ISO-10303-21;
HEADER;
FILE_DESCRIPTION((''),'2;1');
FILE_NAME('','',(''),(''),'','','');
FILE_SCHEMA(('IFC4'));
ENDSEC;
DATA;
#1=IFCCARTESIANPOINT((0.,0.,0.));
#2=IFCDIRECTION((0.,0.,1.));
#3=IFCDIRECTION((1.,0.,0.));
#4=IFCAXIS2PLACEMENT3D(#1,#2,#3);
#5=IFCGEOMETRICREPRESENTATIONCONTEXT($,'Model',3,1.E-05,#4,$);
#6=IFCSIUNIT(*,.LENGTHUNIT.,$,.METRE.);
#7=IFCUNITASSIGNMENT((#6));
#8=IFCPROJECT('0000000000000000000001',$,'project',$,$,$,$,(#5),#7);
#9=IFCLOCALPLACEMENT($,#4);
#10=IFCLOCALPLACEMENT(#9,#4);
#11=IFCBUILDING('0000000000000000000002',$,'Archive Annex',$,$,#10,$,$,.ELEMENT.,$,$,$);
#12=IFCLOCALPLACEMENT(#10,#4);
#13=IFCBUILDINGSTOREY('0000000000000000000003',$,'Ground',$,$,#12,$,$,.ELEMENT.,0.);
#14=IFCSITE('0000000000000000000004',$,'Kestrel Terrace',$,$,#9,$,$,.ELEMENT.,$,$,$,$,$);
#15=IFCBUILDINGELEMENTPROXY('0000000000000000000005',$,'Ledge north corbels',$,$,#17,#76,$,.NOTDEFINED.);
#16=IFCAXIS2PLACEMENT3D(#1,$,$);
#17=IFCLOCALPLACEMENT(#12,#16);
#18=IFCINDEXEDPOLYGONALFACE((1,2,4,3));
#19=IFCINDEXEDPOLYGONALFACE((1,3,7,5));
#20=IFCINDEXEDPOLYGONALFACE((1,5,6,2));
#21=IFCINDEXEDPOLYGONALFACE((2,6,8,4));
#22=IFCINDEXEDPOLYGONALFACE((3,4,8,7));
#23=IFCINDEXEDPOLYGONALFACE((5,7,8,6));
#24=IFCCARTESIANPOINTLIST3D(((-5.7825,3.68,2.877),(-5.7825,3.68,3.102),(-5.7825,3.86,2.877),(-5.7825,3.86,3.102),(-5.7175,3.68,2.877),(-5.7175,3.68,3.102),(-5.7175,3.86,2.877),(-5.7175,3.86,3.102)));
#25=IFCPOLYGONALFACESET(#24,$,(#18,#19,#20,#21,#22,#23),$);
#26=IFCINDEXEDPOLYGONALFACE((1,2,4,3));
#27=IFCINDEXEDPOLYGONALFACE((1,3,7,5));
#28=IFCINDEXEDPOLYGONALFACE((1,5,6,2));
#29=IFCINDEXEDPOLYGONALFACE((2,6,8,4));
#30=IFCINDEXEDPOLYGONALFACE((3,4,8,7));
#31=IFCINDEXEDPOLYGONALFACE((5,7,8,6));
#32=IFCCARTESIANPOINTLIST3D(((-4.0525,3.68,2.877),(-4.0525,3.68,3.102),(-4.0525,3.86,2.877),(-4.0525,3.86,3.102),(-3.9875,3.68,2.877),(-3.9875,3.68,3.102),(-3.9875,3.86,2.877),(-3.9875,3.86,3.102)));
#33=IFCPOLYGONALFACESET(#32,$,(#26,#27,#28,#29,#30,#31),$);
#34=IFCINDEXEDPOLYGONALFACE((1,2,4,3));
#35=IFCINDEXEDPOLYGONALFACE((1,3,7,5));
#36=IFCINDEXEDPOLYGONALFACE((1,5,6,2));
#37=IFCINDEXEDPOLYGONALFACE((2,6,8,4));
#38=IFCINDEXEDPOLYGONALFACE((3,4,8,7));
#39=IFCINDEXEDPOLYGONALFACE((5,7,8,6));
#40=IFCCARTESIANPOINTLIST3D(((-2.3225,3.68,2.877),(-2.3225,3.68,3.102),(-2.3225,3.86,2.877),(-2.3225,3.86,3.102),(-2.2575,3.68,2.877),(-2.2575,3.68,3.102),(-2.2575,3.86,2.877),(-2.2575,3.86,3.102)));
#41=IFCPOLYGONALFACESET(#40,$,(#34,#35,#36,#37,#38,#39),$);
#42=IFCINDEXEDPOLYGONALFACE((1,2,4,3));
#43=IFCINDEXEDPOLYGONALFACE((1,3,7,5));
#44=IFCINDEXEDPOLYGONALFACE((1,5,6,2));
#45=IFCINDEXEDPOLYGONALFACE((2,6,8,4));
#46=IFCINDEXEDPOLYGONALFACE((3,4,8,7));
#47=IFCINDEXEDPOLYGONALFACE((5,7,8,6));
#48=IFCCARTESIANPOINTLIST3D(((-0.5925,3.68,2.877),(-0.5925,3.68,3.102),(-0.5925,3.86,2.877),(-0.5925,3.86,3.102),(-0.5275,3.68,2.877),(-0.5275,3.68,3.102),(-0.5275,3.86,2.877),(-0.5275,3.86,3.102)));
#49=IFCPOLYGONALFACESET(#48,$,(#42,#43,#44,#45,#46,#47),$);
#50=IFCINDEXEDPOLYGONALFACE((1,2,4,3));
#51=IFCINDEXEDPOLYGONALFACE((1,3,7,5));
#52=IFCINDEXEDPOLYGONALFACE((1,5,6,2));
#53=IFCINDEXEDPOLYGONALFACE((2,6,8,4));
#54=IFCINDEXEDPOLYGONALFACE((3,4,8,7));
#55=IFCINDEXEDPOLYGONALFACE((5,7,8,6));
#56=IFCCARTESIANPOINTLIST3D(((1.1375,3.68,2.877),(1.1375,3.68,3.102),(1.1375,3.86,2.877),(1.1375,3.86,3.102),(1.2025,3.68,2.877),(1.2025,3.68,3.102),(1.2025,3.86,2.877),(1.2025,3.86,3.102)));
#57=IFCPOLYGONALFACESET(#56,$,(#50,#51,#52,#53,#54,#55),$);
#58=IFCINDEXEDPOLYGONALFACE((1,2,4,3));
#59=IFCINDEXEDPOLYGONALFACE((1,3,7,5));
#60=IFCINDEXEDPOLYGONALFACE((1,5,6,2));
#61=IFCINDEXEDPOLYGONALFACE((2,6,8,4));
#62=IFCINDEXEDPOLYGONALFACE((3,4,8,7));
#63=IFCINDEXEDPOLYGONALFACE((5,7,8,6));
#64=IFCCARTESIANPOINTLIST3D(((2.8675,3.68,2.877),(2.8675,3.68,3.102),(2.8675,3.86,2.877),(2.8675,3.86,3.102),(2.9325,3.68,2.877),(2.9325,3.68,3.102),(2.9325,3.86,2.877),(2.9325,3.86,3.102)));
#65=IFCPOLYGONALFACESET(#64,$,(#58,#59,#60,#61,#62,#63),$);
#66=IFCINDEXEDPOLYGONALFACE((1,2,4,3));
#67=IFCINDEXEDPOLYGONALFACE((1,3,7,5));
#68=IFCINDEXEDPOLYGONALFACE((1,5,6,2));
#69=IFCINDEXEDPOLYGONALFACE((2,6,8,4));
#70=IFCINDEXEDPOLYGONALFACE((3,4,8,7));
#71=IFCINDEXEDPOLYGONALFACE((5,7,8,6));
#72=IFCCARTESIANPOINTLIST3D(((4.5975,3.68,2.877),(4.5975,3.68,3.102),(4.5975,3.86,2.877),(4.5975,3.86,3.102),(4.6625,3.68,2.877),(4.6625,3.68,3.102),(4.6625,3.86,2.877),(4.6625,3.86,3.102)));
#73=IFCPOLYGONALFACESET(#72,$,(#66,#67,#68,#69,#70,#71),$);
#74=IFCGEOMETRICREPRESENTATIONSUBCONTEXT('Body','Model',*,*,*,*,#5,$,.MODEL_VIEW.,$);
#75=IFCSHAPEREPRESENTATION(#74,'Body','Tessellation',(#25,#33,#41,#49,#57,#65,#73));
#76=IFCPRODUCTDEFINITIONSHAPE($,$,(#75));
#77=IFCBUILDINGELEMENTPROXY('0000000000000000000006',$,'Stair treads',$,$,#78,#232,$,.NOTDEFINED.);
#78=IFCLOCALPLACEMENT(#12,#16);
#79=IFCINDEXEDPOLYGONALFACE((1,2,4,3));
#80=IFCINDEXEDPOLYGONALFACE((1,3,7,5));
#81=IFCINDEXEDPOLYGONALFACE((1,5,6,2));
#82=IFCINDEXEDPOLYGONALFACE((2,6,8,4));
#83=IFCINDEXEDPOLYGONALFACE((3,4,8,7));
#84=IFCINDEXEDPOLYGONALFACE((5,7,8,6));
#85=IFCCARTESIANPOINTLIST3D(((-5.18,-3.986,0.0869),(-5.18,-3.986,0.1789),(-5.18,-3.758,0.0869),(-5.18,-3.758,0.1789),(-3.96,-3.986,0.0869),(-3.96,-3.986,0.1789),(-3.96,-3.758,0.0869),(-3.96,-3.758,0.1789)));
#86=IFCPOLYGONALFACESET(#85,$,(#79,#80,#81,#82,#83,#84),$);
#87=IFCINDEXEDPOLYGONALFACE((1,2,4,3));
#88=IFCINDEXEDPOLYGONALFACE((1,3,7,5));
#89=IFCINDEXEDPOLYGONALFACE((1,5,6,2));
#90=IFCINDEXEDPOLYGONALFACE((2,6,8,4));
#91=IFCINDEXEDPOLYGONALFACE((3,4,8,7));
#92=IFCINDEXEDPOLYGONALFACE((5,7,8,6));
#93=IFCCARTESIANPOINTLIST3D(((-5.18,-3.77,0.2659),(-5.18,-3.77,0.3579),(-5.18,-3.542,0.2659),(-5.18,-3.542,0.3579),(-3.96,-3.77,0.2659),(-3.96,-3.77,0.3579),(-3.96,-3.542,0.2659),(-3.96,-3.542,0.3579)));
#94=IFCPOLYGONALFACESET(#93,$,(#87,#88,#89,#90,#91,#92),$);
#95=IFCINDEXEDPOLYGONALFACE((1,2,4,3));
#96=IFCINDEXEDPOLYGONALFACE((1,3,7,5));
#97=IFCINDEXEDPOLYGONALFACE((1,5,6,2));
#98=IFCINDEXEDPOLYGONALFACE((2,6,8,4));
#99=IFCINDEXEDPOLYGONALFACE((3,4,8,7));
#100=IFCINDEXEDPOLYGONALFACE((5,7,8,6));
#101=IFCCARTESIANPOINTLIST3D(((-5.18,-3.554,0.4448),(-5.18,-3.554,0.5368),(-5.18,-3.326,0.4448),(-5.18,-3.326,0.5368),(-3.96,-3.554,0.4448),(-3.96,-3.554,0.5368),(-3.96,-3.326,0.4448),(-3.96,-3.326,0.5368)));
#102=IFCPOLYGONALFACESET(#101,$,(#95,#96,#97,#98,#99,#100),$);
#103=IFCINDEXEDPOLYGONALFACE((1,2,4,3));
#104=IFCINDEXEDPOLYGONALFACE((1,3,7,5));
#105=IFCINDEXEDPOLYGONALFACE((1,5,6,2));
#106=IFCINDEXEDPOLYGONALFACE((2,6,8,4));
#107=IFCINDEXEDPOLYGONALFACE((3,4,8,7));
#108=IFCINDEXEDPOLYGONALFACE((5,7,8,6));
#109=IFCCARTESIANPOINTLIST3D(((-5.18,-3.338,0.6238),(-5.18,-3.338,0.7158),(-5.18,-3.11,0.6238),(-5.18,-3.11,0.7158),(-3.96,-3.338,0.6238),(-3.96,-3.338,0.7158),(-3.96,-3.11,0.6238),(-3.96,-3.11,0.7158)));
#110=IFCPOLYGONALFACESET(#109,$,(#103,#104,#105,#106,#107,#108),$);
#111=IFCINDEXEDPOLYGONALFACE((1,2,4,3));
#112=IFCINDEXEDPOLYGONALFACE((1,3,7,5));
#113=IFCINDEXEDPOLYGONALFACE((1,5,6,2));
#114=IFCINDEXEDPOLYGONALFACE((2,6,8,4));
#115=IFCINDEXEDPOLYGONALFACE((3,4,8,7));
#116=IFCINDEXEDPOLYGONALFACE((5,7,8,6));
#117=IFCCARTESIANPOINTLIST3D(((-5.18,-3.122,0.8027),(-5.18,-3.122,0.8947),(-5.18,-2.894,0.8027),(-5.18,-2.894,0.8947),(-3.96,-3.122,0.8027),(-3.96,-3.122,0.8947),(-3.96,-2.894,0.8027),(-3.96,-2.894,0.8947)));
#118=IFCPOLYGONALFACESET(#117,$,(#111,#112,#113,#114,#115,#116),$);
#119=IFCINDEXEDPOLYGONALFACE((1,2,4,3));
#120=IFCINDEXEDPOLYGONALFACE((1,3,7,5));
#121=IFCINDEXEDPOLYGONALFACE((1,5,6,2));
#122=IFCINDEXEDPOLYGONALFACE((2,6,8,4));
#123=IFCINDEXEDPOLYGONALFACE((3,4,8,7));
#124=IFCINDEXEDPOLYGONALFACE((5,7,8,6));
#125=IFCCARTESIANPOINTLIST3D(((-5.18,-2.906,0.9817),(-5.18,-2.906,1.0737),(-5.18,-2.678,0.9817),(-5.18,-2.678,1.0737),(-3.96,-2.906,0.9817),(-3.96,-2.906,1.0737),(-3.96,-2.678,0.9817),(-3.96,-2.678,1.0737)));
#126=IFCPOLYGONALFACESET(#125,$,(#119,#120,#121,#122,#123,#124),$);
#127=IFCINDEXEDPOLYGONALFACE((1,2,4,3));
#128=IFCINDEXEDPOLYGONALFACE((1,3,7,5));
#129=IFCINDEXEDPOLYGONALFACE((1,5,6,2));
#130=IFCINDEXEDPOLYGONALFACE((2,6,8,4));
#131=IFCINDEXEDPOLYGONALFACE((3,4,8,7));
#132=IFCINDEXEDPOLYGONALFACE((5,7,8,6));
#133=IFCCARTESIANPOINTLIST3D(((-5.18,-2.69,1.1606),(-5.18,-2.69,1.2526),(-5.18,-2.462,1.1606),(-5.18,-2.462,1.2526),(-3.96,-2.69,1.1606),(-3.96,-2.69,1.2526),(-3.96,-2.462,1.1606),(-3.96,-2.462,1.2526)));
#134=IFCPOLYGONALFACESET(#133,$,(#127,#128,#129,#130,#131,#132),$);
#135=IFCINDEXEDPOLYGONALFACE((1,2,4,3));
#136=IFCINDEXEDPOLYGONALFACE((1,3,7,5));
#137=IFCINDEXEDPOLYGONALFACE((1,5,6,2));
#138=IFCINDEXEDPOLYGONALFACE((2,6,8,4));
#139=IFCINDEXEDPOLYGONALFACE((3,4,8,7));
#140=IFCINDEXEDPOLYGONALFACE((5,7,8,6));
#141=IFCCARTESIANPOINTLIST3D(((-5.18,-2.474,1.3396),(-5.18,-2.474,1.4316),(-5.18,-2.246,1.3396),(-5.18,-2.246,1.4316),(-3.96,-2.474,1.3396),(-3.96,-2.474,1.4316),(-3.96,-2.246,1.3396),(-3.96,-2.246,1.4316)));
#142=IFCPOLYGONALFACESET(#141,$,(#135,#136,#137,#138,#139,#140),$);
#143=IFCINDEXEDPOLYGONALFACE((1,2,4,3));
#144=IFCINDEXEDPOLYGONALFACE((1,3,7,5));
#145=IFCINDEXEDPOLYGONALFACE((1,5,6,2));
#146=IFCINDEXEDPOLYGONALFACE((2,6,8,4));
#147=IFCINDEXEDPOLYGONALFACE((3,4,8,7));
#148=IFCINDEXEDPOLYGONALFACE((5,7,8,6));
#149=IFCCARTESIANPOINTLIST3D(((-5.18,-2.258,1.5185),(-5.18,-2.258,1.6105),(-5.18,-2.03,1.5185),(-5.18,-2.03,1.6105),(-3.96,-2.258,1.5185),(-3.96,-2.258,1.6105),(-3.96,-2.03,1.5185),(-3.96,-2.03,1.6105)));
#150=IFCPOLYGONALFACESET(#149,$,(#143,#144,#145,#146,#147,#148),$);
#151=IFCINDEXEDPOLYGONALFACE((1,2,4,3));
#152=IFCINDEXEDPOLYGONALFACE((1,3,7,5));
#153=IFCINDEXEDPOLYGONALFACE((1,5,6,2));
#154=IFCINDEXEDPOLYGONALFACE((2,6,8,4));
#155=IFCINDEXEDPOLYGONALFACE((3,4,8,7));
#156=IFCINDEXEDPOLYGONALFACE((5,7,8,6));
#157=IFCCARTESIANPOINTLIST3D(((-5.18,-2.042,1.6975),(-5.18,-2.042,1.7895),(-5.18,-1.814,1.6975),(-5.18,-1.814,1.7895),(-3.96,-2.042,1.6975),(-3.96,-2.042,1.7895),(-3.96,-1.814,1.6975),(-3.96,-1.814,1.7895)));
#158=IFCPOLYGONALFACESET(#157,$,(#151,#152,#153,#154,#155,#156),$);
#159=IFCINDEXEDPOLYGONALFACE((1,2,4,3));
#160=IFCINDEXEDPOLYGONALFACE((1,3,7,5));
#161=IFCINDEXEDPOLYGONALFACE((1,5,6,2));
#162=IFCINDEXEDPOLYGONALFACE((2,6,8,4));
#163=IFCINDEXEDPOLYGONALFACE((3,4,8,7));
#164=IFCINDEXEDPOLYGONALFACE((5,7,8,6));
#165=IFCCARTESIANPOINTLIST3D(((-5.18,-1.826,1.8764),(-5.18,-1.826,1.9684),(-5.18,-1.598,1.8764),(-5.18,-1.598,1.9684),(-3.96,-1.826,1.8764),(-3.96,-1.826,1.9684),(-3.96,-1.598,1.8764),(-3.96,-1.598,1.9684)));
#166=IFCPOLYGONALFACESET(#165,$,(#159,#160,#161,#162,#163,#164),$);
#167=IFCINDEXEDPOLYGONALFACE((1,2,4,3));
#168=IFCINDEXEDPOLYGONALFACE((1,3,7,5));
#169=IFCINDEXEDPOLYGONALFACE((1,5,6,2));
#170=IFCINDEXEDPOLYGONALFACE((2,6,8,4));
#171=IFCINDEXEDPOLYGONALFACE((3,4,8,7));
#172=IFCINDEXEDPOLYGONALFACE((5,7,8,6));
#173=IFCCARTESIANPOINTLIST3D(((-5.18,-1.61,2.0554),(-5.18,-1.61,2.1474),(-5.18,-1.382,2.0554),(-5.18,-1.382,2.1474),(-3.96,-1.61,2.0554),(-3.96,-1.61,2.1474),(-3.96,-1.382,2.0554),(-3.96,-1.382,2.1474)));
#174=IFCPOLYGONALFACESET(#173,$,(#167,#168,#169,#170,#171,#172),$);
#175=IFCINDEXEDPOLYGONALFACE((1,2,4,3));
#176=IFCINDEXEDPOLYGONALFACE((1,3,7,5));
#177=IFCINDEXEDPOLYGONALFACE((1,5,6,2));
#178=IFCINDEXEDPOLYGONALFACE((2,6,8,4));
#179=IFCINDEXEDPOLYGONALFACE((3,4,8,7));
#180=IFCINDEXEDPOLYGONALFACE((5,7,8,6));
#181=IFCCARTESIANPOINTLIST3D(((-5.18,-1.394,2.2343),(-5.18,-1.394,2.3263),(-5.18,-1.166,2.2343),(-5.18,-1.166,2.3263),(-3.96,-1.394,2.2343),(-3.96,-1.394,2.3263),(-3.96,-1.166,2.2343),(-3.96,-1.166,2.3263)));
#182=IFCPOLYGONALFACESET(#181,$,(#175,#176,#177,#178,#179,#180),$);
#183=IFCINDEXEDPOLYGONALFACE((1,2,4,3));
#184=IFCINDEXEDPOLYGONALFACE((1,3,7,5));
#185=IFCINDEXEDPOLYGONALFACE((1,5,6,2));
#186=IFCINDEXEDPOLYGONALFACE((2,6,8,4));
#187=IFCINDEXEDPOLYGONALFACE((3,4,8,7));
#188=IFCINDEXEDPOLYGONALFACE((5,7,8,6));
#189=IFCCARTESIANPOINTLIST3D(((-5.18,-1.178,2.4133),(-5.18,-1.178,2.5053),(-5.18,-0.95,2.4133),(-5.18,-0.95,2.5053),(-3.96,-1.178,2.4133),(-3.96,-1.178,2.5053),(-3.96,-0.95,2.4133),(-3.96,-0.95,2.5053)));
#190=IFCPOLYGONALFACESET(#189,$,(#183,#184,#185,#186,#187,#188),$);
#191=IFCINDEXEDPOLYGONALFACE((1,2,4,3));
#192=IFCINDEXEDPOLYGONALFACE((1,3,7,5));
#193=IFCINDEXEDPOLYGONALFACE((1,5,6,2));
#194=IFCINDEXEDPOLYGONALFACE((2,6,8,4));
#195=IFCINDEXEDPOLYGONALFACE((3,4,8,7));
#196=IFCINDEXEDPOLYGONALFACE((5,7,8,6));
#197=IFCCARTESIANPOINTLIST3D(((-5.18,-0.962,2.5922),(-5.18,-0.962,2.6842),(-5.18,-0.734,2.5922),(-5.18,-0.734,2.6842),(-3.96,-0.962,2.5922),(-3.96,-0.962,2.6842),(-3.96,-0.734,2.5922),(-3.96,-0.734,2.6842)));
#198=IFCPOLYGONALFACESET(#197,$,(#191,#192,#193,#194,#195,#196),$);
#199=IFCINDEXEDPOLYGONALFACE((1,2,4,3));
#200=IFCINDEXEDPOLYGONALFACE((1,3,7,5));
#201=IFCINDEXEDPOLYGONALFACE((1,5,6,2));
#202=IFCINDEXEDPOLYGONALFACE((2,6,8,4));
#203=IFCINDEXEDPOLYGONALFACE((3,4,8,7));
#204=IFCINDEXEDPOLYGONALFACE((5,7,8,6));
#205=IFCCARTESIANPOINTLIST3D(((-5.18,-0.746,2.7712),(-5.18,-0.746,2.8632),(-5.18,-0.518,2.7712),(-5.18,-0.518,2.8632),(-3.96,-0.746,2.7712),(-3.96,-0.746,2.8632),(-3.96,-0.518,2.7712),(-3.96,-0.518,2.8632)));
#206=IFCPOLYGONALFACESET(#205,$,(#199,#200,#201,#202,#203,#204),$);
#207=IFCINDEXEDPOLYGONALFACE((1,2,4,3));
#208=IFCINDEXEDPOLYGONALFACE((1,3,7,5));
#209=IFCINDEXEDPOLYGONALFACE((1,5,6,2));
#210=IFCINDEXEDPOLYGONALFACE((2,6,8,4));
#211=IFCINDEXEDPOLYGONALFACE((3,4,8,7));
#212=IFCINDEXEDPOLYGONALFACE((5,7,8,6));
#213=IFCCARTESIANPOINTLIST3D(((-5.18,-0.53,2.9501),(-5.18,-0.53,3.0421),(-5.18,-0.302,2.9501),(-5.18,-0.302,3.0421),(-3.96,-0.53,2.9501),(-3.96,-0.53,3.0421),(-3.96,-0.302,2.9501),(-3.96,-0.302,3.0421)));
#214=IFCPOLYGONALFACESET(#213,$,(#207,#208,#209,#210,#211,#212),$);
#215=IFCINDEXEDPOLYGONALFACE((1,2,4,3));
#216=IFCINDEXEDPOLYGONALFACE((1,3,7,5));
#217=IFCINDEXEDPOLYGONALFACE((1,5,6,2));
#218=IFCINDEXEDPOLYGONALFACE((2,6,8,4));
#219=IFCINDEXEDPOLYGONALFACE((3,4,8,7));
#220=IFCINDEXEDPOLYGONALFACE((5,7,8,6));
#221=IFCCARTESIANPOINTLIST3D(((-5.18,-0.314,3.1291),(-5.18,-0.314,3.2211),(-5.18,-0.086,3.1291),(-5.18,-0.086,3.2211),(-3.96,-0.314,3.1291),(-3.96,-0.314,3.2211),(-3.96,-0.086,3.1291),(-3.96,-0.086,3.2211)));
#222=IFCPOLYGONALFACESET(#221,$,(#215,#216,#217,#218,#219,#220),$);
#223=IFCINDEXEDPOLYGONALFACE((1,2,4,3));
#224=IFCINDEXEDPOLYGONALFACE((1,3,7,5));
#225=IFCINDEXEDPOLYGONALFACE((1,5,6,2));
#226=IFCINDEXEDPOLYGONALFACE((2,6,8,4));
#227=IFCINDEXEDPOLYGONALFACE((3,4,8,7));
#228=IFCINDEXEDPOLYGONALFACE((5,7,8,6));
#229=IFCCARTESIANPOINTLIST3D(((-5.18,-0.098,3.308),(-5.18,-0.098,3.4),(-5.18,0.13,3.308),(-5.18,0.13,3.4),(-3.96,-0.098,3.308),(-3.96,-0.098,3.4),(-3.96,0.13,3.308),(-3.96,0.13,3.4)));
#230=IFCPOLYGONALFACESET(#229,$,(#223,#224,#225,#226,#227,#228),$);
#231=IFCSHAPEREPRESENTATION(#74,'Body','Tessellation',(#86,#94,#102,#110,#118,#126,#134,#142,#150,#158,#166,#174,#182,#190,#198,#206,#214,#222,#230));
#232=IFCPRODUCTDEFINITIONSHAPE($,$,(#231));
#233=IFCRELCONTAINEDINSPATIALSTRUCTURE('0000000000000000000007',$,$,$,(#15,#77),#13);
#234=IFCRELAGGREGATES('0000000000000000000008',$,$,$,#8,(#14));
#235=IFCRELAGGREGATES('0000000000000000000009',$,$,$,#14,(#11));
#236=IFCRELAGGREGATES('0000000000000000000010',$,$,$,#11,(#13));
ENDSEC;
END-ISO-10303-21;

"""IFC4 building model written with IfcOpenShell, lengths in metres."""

from ifc_helpers import new_model, si_unit, frame, origin_with_axes, origin_2d, place, context, subcontext, project, spatial, rectangle, extrude, element, save


model = new_model("IFC4")

# Units and contexts
model_context = context("Model", 3, precision=1e-05, world=origin_with_axes())
body_context = subcontext(model_context, "Body", "Model", "MODEL_VIEW")
ifc_project = project(units=[si_unit("LENGTHUNIT", "METRE")], contexts=[model_context])

# Site, building, storey
site_placement = place(None, origin_with_axes())
site = spatial("IfcSite", under=ifc_project, at=site_placement, Name="Kestrel Terrace", CompositionType="ELEMENT")
building_placement = place(site_placement, origin_with_axes())
building = spatial("IfcBuilding", under=site, at=building_placement, Name="Archive Annex", CompositionType="ELEMENT")
storey_placement = place(building_placement, origin_with_axes())
storey = spatial("IfcBuildingStorey", under=building, at=storey_placement, Name="Ground", CompositionType="ELEMENT", Elevation=0.0)

# Building element proxies
proxy_1_placement = place(storey_placement, origin_with_axes())
element("IfcBuildingElementProxy", 1, at=proxy_1_placement, inside=storey, Name="Ledge north corbels", PredefinedType="NOTDEFINED", context=body_context, shape_type="SweptSolid", body=[
    extrude(rectangle(XDim=0.065, YDim=0.18, at=origin_2d()), frame((-5.75, 3.77, 2.877), z_axis=(0.0, 0.0, 1.0), x_axis=(1.0, 0.0, 0.0)), (0.0, 0.0, 1.0), 0.225),
    extrude(rectangle(XDim=0.065, YDim=0.18, at=origin_2d()), frame((-4.02, 3.77, 2.877), z_axis=(0.0, 0.0, 1.0), x_axis=(1.0, 0.0, 0.0)), (0.0, 0.0, 1.0), 0.225),
    extrude(rectangle(XDim=0.065, YDim=0.18, at=origin_2d()), frame((-2.29, 3.77, 2.877), z_axis=(0.0, 0.0, 1.0), x_axis=(1.0, 0.0, 0.0)), (0.0, 0.0, 1.0), 0.225),
    extrude(rectangle(XDim=0.065, YDim=0.18, at=origin_2d()), frame((-0.56, 3.77, 2.877), z_axis=(0.0, 0.0, 1.0), x_axis=(1.0, 0.0, 0.0)), (0.0, 0.0, 1.0), 0.225),
    extrude(rectangle(XDim=0.065, YDim=0.18, at=origin_2d()), frame((1.17, 3.77, 2.877), z_axis=(0.0, 0.0, 1.0), x_axis=(1.0, 0.0, 0.0)), (0.0, 0.0, 1.0), 0.225),
    extrude(rectangle(XDim=0.065, YDim=0.18, at=origin_2d()), frame((2.9, 3.77, 2.877), z_axis=(0.0, 0.0, 1.0), x_axis=(1.0, 0.0, 0.0)), (0.0, 0.0, 1.0), 0.225),
    extrude(rectangle(XDim=0.065, YDim=0.18, at=origin_2d()), frame((4.63, 3.77, 2.877), z_axis=(0.0, 0.0, 1.0), x_axis=(1.0, 0.0, 0.0)), (0.0, 0.0, 1.0), 0.225),
])
proxy_2_placement = place(storey_placement, origin_with_axes())
element("IfcBuildingElementProxy", 2, at=proxy_2_placement, inside=storey, Name="Stair treads", PredefinedType="NOTDEFINED", context=body_context, shape_type="SweptSolid", body=[
    extrude(rectangle(XDim=1.22, YDim=0.228, at=origin_2d()), frame((-4.57, -3.872, 0.0869), z_axis=(0.0, 0.0, 1.0), x_axis=(1.0, 0.0, 0.0)), (0.0, 0.0, 1.0), 0.092),
    extrude(rectangle(XDim=1.22, YDim=0.228, at=origin_2d()), frame((-4.57, -3.656, 0.2659), z_axis=(0.0, 0.0, 1.0), x_axis=(1.0, 0.0, 0.0)), (0.0, 0.0, 1.0), 0.092),
    extrude(rectangle(XDim=1.22, YDim=0.228, at=origin_2d()), frame((-4.57, -3.44, 0.4448), z_axis=(0.0, 0.0, 1.0), x_axis=(1.0, 0.0, 0.0)), (0.0, 0.0, 1.0), 0.092),
    extrude(rectangle(XDim=1.22, YDim=0.228, at=origin_2d()), frame((-4.57, -3.224, 0.6238), z_axis=(0.0, 0.0, 1.0), x_axis=(1.0, 0.0, 0.0)), (0.0, 0.0, 1.0), 0.092),
    extrude(rectangle(XDim=1.22, YDim=0.228, at=origin_2d()), frame((-4.57, -3.008, 0.8027), z_axis=(0.0, 0.0, 1.0), x_axis=(1.0, 0.0, 0.0)), (0.0, 0.0, 1.0), 0.092),
    extrude(rectangle(XDim=1.22, YDim=0.228, at=origin_2d()), frame((-4.57, -2.792, 0.9817), z_axis=(0.0, 0.0, 1.0), x_axis=(1.0, 0.0, 0.0)), (0.0, 0.0, 1.0), 0.092),
    extrude(rectangle(XDim=1.22, YDim=0.228, at=origin_2d()), frame((-4.57, -2.576, 1.1606), z_axis=(0.0, 0.0, 1.0), x_axis=(1.0, 0.0, 0.0)), (0.0, 0.0, 1.0), 0.092),
    extrude(rectangle(XDim=1.22, YDim=0.228, at=origin_2d()), frame((-4.57, -2.36, 1.3396), z_axis=(0.0, 0.0, 1.0), x_axis=(1.0, 0.0, 0.0)), (0.0, 0.0, 1.0), 0.092),
    extrude(rectangle(XDim=1.22, YDim=0.228, at=origin_2d()), frame((-4.57, -2.144, 1.5185), z_axis=(0.0, 0.0, 1.0), x_axis=(1.0, 0.0, 0.0)), (0.0, 0.0, 1.0), 0.092),
    extrude(rectangle(XDim=1.22, YDim=0.228, at=origin_2d()), frame((-4.57, -1.928, 1.6975), z_axis=(0.0, 0.0, 1.0), x_axis=(1.0, 0.0, 0.0)), (0.0, 0.0, 1.0), 0.092),
    extrude(rectangle(XDim=1.22, YDim=0.228, at=origin_2d()), frame((-4.57, -1.712, 1.8764), z_axis=(0.0, 0.0, 1.0), x_axis=(1.0, 0.0, 0.0)), (0.0, 0.0, 1.0), 0.092),
    extrude(rectangle(XDim=1.22, YDim=0.228, at=origin_2d()), frame((-4.57, -1.496, 2.0554), z_axis=(0.0, 0.0, 1.0), x_axis=(1.0, 0.0, 0.0)), (0.0, 0.0, 1.0), 0.092),
    extrude(rectangle(XDim=1.22, YDim=0.228, at=origin_2d()), frame((-4.57, -1.28, 2.2343), z_axis=(0.0, 0.0, 1.0), x_axis=(1.0, 0.0, 0.0)), (0.0, 0.0, 1.0), 0.092),
    extrude(rectangle(XDim=1.22, YDim=0.228, at=origin_2d()), frame((-4.57, -1.064, 2.4133), z_axis=(0.0, 0.0, 1.0), x_axis=(1.0, 0.0, 0.0)), (0.0, 0.0, 1.0), 0.092),
    extrude(rectangle(XDim=1.22, YDim=0.228, at=origin_2d()), frame((-4.57, -0.848, 2.5922), z_axis=(0.0, 0.0, 1.0), x_axis=(1.0, 0.0, 0.0)), (0.0, 0.0, 1.0), 0.092),
    extrude(rectangle(XDim=1.22, YDim=0.228, at=origin_2d()), frame((-4.57, -0.632, 2.7712), z_axis=(0.0, 0.0, 1.0), x_axis=(1.0, 0.0, 0.0)), (0.0, 0.0, 1.0), 0.092),
    extrude(rectangle(XDim=1.22, YDim=0.228, at=origin_2d()), frame((-4.57, -0.416, 2.9501), z_axis=(0.0, 0.0, 1.0), x_axis=(1.0, 0.0, 0.0)), (0.0, 0.0, 1.0), 0.092),
    extrude(rectangle(XDim=1.22, YDim=0.228, at=origin_2d()), frame((-4.57, -0.2, 3.1291), z_axis=(0.0, 0.0, 1.0), x_axis=(1.0, 0.0, 0.0)), (0.0, 0.0, 1.0), 0.092),
    extrude(rectangle(XDim=1.22, YDim=0.228, at=origin_2d()), frame((-4.57, 0.016, 3.308), z_axis=(0.0, 0.0, 1.0), x_axis=(1.0, 0.0, 0.0)), (0.0, 0.0, 1.0), 0.092),
])

save(model, "model.ifc")
